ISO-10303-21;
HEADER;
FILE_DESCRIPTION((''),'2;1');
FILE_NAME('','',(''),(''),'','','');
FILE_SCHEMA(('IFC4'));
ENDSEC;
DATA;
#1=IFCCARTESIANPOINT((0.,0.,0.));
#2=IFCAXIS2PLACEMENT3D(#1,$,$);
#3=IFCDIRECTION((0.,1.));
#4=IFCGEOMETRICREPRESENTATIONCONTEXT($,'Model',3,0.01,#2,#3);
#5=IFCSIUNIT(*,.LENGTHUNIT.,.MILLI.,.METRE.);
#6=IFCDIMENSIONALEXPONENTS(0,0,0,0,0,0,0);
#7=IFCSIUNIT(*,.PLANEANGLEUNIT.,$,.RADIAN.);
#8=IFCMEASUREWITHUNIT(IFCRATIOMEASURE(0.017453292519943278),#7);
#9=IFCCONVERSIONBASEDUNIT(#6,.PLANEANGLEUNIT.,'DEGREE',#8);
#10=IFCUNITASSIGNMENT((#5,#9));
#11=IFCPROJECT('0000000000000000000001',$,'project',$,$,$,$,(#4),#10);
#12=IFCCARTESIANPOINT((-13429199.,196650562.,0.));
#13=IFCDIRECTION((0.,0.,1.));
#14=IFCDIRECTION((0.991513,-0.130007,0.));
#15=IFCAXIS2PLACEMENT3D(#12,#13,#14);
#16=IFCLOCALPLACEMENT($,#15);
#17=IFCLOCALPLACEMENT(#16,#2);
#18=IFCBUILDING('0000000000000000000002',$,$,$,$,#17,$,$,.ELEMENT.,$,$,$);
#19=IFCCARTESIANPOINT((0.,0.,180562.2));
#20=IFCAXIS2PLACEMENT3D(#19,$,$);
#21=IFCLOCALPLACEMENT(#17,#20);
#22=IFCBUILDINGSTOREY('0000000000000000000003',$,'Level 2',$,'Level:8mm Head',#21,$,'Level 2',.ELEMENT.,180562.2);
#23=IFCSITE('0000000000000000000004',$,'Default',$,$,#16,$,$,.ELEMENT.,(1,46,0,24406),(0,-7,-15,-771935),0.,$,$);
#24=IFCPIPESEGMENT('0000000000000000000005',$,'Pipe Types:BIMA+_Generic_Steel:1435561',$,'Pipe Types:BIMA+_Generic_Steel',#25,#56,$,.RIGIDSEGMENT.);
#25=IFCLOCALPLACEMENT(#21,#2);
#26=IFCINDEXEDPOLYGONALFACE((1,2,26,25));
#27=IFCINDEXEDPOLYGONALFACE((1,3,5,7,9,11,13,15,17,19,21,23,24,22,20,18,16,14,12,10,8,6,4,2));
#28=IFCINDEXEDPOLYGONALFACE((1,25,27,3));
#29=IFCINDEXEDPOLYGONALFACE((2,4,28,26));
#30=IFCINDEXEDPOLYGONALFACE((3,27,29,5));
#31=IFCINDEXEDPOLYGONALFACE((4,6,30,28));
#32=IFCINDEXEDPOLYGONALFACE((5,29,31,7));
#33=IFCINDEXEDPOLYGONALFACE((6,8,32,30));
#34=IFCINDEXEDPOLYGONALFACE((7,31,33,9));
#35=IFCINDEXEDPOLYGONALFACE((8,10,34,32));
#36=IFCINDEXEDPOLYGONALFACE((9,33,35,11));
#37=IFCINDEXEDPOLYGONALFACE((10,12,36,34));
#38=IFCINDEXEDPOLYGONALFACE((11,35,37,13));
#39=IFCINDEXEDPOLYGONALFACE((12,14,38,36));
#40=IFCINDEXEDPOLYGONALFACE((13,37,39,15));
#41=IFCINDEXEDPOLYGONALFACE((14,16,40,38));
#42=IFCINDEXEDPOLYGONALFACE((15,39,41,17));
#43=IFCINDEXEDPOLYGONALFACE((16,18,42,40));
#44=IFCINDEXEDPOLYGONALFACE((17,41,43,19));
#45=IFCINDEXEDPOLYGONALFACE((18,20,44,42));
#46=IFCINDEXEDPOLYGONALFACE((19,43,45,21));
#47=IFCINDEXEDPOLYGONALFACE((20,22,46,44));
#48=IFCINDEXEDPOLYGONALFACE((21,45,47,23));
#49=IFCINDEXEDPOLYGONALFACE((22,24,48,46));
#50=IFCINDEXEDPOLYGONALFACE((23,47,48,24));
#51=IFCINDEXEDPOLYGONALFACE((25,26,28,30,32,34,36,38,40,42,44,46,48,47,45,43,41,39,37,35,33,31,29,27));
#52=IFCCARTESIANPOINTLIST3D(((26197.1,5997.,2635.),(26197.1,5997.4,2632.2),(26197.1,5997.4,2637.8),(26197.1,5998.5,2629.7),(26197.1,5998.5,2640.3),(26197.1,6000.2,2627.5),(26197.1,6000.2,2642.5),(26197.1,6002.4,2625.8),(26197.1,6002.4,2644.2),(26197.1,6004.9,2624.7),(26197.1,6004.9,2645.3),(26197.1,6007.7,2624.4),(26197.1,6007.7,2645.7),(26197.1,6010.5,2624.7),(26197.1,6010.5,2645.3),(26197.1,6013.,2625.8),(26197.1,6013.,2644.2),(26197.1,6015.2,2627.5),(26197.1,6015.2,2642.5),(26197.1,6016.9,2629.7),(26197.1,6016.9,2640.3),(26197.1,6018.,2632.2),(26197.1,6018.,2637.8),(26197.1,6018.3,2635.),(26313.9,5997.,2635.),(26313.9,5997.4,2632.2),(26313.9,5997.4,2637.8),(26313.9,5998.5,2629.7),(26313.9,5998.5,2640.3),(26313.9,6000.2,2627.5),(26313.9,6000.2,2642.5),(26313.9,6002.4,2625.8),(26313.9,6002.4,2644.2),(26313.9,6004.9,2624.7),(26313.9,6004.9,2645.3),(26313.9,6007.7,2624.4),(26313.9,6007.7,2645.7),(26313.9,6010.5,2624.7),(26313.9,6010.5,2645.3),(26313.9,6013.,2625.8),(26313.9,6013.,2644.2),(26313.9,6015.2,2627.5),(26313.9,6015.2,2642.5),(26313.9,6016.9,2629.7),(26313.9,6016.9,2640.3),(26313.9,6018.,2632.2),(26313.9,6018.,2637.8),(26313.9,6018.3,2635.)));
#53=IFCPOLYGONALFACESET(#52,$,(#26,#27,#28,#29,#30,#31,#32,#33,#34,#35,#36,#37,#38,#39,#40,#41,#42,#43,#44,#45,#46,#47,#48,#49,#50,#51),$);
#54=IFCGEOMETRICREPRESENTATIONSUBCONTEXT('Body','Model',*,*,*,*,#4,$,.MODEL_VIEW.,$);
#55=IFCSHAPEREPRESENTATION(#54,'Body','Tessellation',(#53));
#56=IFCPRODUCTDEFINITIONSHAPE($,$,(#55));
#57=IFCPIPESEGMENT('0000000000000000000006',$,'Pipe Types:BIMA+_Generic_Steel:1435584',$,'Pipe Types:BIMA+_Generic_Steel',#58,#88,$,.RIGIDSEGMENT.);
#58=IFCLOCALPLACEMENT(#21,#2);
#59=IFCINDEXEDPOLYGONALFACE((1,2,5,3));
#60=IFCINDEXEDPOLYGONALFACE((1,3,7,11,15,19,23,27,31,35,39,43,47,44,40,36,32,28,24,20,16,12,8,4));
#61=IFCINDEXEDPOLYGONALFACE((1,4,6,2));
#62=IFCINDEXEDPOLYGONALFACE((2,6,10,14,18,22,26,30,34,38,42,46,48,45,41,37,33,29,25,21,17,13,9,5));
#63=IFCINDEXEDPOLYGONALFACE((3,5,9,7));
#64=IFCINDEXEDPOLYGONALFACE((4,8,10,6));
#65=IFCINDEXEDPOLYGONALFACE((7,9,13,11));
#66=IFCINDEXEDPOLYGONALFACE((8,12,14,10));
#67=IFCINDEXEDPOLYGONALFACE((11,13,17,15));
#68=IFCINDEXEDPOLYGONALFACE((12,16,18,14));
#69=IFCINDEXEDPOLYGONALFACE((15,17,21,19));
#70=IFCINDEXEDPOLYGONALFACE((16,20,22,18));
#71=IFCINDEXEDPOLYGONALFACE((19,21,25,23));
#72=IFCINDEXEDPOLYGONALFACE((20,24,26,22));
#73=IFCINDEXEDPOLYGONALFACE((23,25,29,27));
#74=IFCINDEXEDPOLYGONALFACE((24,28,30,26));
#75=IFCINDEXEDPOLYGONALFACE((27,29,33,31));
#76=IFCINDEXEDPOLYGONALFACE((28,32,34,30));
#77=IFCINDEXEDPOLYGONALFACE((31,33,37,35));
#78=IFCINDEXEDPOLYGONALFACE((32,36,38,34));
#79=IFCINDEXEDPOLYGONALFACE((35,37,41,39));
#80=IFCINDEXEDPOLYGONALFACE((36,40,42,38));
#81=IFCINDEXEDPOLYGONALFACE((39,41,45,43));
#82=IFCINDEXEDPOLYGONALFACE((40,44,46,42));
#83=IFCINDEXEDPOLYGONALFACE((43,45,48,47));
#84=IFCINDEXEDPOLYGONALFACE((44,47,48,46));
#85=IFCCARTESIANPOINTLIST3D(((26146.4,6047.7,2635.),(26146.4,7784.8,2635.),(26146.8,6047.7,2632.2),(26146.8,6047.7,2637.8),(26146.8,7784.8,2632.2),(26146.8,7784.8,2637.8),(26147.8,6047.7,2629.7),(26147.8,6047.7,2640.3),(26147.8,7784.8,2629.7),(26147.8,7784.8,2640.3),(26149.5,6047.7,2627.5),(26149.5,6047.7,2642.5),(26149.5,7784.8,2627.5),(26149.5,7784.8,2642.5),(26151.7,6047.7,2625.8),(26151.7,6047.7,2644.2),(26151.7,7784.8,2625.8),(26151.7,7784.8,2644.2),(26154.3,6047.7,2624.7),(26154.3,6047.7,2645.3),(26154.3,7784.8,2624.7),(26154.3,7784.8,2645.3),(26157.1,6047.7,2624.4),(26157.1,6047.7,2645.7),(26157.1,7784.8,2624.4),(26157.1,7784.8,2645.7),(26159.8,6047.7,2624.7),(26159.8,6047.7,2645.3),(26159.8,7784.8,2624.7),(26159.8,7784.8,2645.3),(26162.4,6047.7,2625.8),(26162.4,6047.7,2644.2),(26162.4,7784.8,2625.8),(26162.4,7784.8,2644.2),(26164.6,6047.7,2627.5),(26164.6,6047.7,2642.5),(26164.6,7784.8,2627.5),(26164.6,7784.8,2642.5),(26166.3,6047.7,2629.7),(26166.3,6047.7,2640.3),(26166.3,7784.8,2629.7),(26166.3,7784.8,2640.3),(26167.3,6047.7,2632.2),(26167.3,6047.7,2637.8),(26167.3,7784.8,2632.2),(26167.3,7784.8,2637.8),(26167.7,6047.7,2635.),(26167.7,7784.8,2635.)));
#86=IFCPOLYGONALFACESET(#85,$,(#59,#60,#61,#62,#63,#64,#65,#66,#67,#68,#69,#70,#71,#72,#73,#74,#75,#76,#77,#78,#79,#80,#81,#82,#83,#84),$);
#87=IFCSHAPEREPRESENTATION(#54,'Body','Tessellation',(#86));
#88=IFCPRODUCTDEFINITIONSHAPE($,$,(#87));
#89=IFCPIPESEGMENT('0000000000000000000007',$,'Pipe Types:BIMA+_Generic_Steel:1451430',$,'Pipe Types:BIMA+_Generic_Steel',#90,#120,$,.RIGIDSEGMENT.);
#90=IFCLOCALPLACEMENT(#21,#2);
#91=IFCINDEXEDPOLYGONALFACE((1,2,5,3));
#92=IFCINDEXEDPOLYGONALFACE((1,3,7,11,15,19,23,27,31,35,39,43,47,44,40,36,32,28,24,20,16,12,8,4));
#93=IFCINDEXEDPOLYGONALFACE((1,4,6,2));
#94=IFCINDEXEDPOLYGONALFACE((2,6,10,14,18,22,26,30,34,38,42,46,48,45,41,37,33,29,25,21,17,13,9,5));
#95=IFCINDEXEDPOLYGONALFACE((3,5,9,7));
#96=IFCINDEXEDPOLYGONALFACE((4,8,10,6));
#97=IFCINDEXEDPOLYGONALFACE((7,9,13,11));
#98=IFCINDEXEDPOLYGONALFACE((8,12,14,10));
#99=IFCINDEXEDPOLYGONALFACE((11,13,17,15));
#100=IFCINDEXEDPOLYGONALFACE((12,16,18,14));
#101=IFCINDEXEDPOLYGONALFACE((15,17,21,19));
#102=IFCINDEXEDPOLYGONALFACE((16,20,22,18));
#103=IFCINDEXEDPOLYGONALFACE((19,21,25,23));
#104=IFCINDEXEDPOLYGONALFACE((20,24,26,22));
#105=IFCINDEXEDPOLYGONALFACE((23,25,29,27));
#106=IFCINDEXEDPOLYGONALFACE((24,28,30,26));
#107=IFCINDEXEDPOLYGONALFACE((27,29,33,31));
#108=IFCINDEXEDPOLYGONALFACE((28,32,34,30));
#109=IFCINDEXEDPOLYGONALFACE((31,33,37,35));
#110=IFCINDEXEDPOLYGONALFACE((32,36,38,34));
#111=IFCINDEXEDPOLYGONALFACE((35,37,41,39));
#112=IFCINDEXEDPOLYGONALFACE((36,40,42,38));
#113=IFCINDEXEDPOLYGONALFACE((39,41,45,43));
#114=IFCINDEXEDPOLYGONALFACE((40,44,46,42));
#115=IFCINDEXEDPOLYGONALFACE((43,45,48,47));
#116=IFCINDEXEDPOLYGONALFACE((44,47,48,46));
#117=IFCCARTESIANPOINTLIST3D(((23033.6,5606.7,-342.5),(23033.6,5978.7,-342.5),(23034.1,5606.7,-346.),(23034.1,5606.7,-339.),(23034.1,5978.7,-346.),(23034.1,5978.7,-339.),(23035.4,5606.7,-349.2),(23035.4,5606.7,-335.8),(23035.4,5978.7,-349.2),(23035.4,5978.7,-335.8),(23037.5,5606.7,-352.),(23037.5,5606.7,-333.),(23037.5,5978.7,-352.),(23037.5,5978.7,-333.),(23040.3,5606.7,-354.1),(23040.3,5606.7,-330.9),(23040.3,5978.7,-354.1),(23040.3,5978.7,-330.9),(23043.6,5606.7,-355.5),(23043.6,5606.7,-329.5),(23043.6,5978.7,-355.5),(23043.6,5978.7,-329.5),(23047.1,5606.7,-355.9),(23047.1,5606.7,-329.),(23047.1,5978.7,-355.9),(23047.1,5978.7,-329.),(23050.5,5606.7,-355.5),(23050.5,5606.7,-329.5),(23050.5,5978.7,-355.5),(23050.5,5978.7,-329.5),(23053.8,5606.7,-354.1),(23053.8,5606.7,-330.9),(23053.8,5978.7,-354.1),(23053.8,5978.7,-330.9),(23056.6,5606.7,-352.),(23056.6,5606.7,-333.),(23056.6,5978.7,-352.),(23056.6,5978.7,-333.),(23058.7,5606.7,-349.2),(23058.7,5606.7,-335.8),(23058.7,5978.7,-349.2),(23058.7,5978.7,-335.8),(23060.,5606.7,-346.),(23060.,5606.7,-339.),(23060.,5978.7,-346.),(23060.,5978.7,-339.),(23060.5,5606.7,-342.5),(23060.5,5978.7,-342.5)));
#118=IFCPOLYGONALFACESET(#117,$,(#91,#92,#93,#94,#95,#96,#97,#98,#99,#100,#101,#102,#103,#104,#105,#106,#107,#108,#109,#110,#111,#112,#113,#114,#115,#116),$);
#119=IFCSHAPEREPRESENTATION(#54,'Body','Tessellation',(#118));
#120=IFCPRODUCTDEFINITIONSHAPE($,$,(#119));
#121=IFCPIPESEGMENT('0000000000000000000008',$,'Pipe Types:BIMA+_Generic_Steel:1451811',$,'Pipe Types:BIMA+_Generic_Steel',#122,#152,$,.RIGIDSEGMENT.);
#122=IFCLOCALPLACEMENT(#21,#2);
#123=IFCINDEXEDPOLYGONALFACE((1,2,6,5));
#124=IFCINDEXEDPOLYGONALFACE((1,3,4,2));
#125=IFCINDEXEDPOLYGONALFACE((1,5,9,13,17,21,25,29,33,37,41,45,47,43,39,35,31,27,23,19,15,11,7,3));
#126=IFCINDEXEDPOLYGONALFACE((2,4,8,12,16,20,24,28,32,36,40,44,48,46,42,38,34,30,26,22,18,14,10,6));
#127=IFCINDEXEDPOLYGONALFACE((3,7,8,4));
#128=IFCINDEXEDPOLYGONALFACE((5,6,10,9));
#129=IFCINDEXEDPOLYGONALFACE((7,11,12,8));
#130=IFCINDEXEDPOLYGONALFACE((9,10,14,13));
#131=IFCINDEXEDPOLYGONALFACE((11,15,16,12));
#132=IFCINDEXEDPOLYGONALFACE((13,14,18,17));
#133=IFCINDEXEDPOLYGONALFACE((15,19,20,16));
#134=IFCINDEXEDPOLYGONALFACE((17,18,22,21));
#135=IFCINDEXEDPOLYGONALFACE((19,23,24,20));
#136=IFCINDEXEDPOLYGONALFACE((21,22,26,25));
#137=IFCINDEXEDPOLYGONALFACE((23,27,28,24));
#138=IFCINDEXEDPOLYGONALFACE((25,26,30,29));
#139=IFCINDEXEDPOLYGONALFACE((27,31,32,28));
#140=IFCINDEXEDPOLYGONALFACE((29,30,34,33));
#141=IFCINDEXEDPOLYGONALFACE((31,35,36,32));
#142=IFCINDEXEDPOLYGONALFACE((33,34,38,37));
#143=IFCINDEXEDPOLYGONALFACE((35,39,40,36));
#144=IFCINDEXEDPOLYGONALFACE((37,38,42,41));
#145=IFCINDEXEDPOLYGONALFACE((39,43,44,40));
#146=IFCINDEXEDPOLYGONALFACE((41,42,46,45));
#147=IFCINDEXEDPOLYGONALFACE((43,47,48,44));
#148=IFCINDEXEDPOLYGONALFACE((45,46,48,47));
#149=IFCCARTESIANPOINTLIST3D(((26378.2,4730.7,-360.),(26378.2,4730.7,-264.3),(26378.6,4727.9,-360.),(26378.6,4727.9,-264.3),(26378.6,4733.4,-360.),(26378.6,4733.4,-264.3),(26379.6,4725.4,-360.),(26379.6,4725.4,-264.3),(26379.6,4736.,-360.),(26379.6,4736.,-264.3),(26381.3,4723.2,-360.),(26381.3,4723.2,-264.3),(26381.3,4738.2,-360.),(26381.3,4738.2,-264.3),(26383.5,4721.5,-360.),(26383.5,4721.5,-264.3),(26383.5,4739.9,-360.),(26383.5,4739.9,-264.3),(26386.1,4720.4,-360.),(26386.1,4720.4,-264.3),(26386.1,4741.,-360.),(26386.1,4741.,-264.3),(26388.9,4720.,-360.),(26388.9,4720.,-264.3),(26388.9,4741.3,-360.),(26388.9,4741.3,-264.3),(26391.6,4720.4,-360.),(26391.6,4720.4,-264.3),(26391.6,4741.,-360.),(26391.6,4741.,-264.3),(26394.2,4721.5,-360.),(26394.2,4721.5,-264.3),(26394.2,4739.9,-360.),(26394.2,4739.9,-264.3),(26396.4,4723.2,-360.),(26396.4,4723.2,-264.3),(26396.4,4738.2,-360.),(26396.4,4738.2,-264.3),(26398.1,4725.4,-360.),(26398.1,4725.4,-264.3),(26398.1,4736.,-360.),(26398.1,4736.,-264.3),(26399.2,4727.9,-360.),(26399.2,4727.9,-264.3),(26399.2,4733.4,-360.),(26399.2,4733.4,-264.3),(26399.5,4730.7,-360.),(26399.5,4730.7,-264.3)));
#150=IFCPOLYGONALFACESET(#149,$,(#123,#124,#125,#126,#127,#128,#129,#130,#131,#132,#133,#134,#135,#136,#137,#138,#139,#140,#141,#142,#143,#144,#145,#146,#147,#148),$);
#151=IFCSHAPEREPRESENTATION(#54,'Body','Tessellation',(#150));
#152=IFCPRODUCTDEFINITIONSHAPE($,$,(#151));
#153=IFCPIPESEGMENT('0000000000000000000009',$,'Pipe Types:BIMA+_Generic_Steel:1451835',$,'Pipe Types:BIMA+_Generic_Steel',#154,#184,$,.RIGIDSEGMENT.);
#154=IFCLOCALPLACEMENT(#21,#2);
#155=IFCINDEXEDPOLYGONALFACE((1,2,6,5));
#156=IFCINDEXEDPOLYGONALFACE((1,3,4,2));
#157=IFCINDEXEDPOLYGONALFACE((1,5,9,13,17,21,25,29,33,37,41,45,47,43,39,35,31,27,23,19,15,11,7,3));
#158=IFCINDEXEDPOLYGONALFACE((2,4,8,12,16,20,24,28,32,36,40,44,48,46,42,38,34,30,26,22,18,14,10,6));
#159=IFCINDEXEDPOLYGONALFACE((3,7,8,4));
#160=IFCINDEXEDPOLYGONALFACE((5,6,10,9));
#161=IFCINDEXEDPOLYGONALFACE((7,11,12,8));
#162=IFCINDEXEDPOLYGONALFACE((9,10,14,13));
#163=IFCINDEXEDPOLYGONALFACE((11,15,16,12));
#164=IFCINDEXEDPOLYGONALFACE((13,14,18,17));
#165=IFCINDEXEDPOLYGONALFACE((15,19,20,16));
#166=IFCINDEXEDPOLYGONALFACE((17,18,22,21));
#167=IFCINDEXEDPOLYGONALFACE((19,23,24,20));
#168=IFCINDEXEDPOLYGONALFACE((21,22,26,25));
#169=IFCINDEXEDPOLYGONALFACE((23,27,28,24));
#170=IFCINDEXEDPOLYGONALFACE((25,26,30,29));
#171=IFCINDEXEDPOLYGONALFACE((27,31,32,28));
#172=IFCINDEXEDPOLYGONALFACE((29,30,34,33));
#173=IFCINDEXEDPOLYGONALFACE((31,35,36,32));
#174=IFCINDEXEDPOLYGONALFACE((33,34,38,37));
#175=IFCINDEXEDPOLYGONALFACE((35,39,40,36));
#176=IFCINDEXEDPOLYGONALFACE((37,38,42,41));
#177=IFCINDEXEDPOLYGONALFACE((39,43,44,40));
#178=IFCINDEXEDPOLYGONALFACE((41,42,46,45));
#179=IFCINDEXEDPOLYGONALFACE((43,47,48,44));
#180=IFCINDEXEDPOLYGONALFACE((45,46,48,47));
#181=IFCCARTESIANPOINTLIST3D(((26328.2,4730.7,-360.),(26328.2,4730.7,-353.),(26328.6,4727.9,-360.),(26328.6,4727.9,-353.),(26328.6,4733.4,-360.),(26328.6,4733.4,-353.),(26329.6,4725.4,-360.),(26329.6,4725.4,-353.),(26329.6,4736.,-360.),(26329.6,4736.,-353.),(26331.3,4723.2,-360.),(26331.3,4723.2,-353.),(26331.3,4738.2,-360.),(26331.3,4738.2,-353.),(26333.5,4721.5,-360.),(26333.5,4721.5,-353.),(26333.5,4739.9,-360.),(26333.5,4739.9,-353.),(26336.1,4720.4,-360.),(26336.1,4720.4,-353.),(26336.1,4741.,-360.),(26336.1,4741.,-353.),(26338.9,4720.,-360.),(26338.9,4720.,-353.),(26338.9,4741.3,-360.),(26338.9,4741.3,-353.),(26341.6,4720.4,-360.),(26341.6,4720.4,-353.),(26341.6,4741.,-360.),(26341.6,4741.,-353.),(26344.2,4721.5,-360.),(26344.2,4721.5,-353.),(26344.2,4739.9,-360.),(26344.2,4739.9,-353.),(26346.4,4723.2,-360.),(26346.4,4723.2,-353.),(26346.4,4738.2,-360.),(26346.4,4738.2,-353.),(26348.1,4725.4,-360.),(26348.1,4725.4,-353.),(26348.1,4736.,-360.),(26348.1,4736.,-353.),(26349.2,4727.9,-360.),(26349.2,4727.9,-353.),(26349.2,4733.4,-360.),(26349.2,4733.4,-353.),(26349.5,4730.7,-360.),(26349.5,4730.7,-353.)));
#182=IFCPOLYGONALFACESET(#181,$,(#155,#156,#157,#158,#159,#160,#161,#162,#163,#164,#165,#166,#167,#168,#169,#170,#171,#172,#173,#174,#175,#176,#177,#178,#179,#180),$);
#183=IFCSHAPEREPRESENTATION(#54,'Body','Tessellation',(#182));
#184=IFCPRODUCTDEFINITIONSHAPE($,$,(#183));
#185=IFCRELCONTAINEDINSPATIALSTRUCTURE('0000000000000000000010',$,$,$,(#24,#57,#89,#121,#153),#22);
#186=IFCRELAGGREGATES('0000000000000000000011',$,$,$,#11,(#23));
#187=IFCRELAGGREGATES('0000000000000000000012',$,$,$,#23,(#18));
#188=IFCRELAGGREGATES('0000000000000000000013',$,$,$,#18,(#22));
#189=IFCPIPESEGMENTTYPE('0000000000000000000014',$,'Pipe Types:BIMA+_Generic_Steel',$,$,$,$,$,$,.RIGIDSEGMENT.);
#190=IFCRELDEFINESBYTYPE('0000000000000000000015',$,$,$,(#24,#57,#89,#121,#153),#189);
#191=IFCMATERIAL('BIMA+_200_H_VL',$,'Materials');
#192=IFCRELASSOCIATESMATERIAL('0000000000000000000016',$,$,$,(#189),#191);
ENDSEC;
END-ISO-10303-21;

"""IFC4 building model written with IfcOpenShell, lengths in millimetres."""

from ifc_helpers import new_model, entity, si_unit, converted_unit, direction, frame, origin, place, context, subcontext, project, spatial, arc, indexed_curve, outline, extrude, material, type_object, element, save


model = new_model("IFC4")

# Units and contexts
model_context = context("Model", 3, precision=0.01, world=origin(), true_north=direction((0.0, 1.0)))
body_context = subcontext(model_context, "Body", "Model", "MODEL_VIEW")
ifc_project = project(units=[si_unit("LENGTHUNIT", "METRE", prefix="MILLI"), converted_unit("PLANEANGLEUNIT", "DEGREE", entity("IfcRatioMeasure", 0.017453292519943278), si_unit("PLANEANGLEUNIT", "RADIAN"), dimensions=[0, 0, 0, 0, 0, 0, 0])], contexts=[model_context])

# Site, building, storey
site_placement = place(None, frame((-13429199.0, 196650562.0, 0.0), z_axis=(0.0, 0.0, 1.0), x_axis=(0.991513, -0.130007, 0.0)))
site = spatial("IfcSite", under=ifc_project, at=site_placement, Name="Default", CompositionType="ELEMENT", RefLatitude=(1, 46, 0, 24406), RefLongitude=(0, -7, -15, -771935), RefElevation=0.0)
building_placement = place(site_placement, origin())
building = spatial("IfcBuilding", under=site, at=building_placement, CompositionType="ELEMENT")
storey_placement = place(building_placement, frame((0.0, 0.0, 180562.2)))
storey = spatial("IfcBuildingStorey", under=building, at=storey_placement, Name="Level 2", ObjectType="Level:8mm Head", LongName="Level 2", CompositionType="ELEMENT", Elevation=180562.2)

# Pipe segments
ifc_material_1 = material(Name="BIMA+_200_H_VL", Category="Materials")
pipe_segment_type = type_object("IfcPipeSegmentType", Name="Pipe Types:BIMA+_Generic_Steel", PredefinedType="RIGIDSEGMENT", material=ifc_material_1)
pipe_segment_1_placement = place(storey_placement, frame((26197.1, 5995.5, 2622.8)))
element("IfcPipeSegment", 1, at=pipe_segment_1_placement, inside=storey, type_object=pipe_segment_type, Name="Pipe Types:BIMA+_Generic_Steel:1435561", ObjectType="Pipe Types:BIMA+_Generic_Steel", PredefinedType="RIGIDSEGMENT", context=body_context, shape_type="SweptSolid", body=[
    extrude(outline(indexed_curve([(10.6, 0.0), (7.5, 7.5), (0.0, 10.7), (-7.5, 7.5), (-10.7, 0.0), (-7.5, -7.5), (0.0, -10.7), (7.5, -7.5)], segments=[arc(1, 2, 3), arc(3, 4, 5), arc(5, 6, 7), arc(7, 8, 1)], self_intersect=False)), frame((0.0, 12.2, 12.2), z_axis=(1.0, 0.0, 0.0), x_axis=(0.0, 1.0, 0.0)), (0.0, 0.0, 1.0), 116.8),
])
pipe_segment_2_placement = place(storey_placement, frame((26144.8, 6047.7, 2622.8)))
element("IfcPipeSegment", 2, at=pipe_segment_2_placement, inside=storey, type_object=pipe_segment_type, Name="Pipe Types:BIMA+_Generic_Steel:1435584", ObjectType="Pipe Types:BIMA+_Generic_Steel", PredefinedType="RIGIDSEGMENT", context=body_context, shape_type="SweptSolid", body=[
    extrude(outline(indexed_curve([(10.7, 0.0), (7.5, 7.5), (0.0, 10.7), (-7.5, 7.5), (-10.7, 0.0), (-7.5, -7.5), (0.0, -10.7), (7.5, -7.5)], segments=[arc(1, 2, 3), arc(3, 4, 5), arc(5, 6, 7), arc(7, 8, 1)], self_intersect=False)), frame((12.2, 0.0, 12.2), z_axis=(0.0, 1.0, 0.0), x_axis=(-1.0, 0.0, 0.0)), (0.0, 0.0, 1.0), 1737.1),
])
pipe_segment_3_placement = place(storey_placement, frame((23032.0, 5606.7, -357.5)))
element("IfcPipeSegment", 3, at=pipe_segment_3_placement, inside=storey, type_object=pipe_segment_type, Name="Pipe Types:BIMA+_Generic_Steel:1451430", ObjectType="Pipe Types:BIMA+_Generic_Steel", PredefinedType="RIGIDSEGMENT", context=body_context, shape_type="SweptSolid", body=[
    extrude(outline(indexed_curve([(13.5, 0.0), (9.5, 9.5), (0.0, 13.5), (-9.5, 9.5), (-13.5, 0.0), (-9.5, -9.5), (0.0, -13.5), (9.5, -9.5)], segments=[arc(1, 2, 3), arc(3, 4, 5), arc(5, 6, 7), arc(7, 8, 1)], self_intersect=False)), frame((15.0, 0.0, 15.0), z_axis=(0.0, 1.0, 0.0), x_axis=(-1.0, 0.0, 0.0)), (0.0, 0.0, 1.0), 372.0),
])
pipe_segment_4_placement = place(storey_placement, frame((26376.6, 4718.4, -264.3)))
element("IfcPipeSegment", 4, at=pipe_segment_4_placement, inside=storey, type_object=pipe_segment_type, Name="Pipe Types:BIMA+_Generic_Steel:1451811", ObjectType="Pipe Types:BIMA+_Generic_Steel", PredefinedType="RIGIDSEGMENT", context=body_context, shape_type="SweptSolid", body=[
    extrude(outline(indexed_curve([(10.7, 0.0), (7.5, 7.5), (0.0, 10.6), (-7.5, 7.5), (-10.7, 0.0), (-7.5, -7.5), (0.0, -10.6), (7.5, -7.5)], segments=[arc(1, 2, 3), arc(3, 4, 5), arc(5, 6, 7), arc(7, 8, 1)], self_intersect=False)), frame((12.2, 12.2, -95.7), z_axis=(0.0, 0.0, 1.0), x_axis=(-1.0, 0.0, 0.0)), (0.0, 0.0, 1.0), 95.7),
])
pipe_segment_5_placement = place(storey_placement, frame((26326.6, 4718.4, -353.0)))
element("IfcPipeSegment", 5, at=pipe_segment_5_placement, inside=storey, type_object=pipe_segment_type, Name="Pipe Types:BIMA+_Generic_Steel:1451835", ObjectType="Pipe Types:BIMA+_Generic_Steel", PredefinedType="RIGIDSEGMENT", context=body_context, shape_type="SweptSolid", body=[
    extrude(outline(indexed_curve([(10.7, 0.0), (7.5, 7.5), (0.0, 10.6), (-7.5, 7.5), (-10.7, 0.0), (-7.5, -7.5), (0.0, -10.6), (7.5, -7.5)], segments=[arc(1, 2, 3), arc(3, 4, 5), arc(5, 6, 7), arc(7, 8, 1)], self_intersect=False)), frame((12.2, 12.2, -7.0), z_axis=(0.0, 0.0, 1.0), x_axis=(-1.0, 0.0, 0.0)), (0.0, 0.0, 1.0), 7.0),
])

save(model, "model.ifc")
